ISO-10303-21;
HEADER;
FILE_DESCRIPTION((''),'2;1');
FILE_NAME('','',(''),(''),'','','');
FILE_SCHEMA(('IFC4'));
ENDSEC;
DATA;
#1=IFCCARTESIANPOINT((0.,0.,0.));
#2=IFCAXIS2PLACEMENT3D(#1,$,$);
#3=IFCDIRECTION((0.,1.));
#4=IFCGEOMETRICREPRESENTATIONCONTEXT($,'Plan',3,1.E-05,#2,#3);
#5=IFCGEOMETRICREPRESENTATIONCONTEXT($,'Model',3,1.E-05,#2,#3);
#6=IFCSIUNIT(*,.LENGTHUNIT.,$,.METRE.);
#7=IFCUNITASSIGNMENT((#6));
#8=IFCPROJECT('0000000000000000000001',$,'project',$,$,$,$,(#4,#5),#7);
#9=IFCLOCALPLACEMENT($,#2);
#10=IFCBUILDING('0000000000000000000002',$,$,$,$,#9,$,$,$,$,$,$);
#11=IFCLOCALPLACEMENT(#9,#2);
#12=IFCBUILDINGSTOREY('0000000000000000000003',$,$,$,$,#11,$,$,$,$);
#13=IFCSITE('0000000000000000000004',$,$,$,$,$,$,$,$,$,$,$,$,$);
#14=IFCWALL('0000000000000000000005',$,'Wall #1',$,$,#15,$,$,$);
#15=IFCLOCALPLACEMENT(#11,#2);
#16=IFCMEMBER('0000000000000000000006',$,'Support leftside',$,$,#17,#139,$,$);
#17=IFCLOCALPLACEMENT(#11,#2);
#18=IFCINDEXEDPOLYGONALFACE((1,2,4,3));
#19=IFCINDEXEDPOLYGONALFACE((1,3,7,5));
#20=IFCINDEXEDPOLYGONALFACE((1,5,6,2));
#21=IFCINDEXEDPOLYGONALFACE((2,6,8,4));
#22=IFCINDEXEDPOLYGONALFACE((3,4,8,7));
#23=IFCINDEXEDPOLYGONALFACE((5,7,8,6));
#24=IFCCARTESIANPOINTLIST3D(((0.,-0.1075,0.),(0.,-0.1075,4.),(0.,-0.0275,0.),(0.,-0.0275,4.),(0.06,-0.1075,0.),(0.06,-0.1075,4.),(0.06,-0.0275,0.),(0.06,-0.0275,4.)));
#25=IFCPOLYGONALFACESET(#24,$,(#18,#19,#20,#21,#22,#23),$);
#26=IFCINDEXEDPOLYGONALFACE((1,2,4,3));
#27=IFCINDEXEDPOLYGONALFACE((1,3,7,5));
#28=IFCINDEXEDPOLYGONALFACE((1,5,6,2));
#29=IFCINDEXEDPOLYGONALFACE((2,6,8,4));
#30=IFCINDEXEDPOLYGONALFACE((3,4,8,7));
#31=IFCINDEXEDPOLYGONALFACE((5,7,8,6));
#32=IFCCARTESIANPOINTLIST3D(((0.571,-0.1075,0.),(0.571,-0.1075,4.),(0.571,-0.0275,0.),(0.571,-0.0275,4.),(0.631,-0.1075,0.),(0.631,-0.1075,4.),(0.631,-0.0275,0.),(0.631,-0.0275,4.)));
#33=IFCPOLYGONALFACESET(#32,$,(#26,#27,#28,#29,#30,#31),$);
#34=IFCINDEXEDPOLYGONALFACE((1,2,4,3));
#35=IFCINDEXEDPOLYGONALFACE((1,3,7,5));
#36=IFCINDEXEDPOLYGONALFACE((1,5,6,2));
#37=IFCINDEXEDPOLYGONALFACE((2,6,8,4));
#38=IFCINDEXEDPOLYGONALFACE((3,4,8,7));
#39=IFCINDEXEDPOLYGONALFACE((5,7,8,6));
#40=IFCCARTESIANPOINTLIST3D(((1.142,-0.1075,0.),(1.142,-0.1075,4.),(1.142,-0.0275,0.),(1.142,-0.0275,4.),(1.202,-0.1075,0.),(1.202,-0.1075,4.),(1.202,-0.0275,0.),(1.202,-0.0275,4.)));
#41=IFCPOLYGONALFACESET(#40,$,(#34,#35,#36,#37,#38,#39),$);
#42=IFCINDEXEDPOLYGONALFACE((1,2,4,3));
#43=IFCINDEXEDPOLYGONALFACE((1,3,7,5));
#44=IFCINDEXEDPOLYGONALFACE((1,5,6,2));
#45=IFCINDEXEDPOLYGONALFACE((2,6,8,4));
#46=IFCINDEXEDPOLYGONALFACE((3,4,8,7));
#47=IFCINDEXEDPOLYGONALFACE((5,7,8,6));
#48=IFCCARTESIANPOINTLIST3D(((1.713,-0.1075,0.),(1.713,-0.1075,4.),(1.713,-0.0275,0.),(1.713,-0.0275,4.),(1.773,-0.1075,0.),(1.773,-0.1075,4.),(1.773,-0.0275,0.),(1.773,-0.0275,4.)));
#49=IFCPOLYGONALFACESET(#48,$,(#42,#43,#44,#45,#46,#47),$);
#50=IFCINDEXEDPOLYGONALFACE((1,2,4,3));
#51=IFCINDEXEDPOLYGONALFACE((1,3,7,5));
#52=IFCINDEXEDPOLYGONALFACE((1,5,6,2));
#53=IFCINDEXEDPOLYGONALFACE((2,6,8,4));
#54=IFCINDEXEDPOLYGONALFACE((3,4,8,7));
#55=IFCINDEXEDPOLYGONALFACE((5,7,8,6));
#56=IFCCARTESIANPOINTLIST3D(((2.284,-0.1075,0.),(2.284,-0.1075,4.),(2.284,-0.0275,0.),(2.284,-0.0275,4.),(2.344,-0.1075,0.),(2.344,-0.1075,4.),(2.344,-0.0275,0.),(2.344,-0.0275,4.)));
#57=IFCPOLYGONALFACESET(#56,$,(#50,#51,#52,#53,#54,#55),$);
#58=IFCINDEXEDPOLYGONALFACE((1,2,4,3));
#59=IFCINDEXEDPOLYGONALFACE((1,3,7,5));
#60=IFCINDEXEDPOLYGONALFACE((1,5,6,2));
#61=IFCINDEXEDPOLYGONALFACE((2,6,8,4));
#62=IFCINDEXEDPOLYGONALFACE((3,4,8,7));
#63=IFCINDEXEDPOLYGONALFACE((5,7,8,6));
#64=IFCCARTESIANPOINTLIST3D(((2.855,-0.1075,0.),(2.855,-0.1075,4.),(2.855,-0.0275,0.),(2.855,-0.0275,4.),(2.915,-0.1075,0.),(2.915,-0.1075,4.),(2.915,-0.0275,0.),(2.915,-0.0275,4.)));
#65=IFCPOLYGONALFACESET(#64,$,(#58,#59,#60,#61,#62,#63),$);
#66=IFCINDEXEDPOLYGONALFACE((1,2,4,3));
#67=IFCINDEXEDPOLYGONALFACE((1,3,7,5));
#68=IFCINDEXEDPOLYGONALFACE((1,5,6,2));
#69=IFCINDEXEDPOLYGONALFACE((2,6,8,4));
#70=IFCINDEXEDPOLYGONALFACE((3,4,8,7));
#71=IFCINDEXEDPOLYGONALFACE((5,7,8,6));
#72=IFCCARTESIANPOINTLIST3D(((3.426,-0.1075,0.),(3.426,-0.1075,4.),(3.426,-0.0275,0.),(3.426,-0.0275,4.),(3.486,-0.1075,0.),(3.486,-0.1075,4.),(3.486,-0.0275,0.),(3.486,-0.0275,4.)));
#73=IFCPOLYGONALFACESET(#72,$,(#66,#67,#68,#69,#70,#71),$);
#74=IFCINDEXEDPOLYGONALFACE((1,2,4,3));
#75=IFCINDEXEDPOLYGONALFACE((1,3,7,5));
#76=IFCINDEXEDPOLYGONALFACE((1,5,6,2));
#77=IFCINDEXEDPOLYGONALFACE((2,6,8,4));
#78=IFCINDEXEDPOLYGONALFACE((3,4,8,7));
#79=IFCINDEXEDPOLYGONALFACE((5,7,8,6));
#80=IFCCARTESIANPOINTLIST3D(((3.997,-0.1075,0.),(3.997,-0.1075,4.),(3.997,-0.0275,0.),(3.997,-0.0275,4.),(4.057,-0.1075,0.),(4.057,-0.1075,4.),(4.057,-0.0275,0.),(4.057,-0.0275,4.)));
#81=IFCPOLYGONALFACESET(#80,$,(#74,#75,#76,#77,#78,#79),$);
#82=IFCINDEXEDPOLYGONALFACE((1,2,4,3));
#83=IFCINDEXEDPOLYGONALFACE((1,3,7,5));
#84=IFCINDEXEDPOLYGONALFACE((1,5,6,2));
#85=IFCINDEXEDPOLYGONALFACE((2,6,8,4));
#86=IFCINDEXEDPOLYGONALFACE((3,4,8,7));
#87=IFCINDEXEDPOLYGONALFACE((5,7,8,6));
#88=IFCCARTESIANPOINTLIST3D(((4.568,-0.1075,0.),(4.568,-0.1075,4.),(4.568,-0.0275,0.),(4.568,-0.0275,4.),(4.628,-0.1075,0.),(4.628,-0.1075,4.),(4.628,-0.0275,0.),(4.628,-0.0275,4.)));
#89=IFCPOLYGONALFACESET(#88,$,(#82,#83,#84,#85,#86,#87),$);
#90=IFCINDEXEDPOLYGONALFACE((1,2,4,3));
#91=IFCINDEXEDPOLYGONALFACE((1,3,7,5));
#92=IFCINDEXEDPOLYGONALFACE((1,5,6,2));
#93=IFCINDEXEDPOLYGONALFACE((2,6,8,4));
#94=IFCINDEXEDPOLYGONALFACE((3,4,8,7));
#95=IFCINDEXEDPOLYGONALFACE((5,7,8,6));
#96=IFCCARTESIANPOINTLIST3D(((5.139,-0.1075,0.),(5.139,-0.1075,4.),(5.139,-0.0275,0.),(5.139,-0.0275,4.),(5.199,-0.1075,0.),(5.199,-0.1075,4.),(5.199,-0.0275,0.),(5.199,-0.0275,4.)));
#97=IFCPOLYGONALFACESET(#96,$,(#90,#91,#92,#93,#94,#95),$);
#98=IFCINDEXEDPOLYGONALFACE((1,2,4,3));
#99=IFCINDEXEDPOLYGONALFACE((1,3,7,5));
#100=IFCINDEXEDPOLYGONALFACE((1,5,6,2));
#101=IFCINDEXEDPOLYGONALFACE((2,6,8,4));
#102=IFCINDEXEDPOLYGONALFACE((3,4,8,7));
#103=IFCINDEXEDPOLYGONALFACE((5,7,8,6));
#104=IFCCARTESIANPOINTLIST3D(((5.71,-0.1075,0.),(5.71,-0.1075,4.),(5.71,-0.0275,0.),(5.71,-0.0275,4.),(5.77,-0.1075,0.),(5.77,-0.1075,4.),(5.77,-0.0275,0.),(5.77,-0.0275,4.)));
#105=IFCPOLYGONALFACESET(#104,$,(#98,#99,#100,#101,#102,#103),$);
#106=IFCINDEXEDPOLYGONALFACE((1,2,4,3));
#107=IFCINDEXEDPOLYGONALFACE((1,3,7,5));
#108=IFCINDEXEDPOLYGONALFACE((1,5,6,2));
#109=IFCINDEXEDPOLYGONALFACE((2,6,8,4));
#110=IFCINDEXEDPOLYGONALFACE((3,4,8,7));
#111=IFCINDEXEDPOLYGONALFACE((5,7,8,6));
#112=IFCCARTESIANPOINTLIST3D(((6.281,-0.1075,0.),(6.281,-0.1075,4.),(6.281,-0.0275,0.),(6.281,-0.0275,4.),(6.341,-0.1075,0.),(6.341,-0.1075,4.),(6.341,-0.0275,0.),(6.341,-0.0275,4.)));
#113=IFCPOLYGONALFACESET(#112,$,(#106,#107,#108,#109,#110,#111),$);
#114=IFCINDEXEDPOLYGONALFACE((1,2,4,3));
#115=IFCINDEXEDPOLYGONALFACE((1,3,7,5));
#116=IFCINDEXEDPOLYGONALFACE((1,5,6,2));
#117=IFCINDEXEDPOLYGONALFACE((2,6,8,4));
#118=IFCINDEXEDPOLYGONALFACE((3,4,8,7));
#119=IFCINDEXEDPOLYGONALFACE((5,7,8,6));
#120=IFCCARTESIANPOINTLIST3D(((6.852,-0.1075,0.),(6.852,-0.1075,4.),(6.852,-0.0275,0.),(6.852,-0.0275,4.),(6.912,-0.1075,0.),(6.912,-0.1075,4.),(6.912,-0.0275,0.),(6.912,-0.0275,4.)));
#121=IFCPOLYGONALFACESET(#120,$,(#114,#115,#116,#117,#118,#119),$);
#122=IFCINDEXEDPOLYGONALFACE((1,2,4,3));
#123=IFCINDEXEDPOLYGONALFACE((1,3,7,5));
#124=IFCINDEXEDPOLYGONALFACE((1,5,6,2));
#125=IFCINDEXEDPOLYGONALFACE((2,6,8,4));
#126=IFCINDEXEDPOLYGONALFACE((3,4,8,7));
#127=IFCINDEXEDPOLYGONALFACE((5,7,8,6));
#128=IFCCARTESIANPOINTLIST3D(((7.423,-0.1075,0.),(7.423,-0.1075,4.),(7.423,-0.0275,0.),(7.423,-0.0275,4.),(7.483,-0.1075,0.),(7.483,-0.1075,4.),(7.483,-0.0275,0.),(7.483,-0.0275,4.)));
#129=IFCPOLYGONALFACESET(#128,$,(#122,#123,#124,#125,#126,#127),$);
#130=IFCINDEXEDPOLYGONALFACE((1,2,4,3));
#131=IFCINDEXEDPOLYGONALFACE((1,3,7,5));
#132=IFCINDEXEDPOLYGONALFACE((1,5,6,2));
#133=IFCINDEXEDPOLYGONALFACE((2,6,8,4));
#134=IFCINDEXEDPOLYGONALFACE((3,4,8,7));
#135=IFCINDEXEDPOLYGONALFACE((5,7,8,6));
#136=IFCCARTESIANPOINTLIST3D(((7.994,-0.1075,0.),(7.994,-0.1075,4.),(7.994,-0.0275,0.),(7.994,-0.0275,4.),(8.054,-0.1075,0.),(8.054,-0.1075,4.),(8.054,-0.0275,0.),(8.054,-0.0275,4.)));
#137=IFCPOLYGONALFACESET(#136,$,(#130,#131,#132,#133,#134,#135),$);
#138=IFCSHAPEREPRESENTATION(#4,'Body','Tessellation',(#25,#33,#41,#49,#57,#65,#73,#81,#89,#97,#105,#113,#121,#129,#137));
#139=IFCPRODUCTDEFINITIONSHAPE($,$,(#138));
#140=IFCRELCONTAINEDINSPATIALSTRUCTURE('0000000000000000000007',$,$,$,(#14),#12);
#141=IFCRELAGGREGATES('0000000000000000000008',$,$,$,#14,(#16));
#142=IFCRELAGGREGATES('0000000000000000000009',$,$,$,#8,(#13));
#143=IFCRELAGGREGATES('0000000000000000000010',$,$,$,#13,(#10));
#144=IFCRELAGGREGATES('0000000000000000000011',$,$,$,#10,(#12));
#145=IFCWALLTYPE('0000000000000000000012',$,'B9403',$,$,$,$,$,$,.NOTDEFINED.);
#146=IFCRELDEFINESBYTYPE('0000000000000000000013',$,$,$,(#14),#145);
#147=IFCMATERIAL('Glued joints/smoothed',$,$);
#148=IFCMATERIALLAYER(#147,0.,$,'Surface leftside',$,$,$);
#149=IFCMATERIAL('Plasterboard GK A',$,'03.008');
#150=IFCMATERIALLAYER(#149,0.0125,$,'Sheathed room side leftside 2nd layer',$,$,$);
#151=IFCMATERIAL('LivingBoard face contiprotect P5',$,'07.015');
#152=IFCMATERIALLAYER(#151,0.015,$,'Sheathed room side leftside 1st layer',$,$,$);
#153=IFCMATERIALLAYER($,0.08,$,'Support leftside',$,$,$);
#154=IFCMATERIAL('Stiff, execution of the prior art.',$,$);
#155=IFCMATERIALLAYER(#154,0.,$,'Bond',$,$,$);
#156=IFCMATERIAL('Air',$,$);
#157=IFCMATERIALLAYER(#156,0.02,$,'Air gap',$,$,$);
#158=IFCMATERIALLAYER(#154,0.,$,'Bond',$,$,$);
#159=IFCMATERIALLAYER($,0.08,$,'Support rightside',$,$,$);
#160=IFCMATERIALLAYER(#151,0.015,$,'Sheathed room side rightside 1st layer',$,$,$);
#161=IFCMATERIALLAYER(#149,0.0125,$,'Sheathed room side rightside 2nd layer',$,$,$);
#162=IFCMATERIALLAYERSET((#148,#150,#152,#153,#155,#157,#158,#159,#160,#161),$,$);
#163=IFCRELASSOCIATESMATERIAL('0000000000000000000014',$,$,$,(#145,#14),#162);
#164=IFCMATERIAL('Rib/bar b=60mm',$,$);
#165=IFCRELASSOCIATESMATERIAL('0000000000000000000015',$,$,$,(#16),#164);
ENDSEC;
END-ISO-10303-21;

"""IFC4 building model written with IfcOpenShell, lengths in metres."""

from ifc_helpers import new_model, si_unit, direction, frame, frame_2d, origin, place, context, project, spatial, rectangle, extrude, material, layer, layer_set, type_object, element, aggregate, save


model = new_model("IFC4")

# Units and contexts
plan_context = context("Plan", 3, precision=1e-05, world=origin(), true_north=direction((0.0, 1.0)))
model_context = context("Model", 3, precision=1e-05, world=origin(), true_north=direction((0.0, 1.0)))
ifc_project = project(units=[si_unit("LENGTHUNIT", "METRE")], contexts=[plan_context, model_context])

# Site, building, storey
site = spatial("IfcSite", under=ifc_project)
building_placement = place(None, origin())
building = spatial("IfcBuilding", under=site, at=building_placement)
storey_placement = place(building_placement, origin())
storey = spatial("IfcBuildingStorey", under=building, at=storey_placement)

# Wall, member
ifc_material_1 = material(Name="Glued joints/smoothed")
ifc_layer_1 = layer(ifc_material_1, 0.0, Name="Surface leftside")
ifc_material_2 = material(Name="Plasterboard GK A", Category="03.008")
ifc_layer_2 = layer(ifc_material_2, 0.0125, Name="Sheathed room side leftside 2nd layer")
ifc_material_3 = material(Name="LivingBoard face contiprotect P5", Category="07.015")
ifc_layer_3 = layer(ifc_material_3, 0.015, Name="Sheathed room side leftside 1st layer")
ifc_layer_4 = layer(None, 0.08, Name="Support leftside")
ifc_material_4 = material(Name="Stiff, execution of the prior art.")
ifc_layer_5 = layer(ifc_material_4, 0.0, Name="Bond")
ifc_material_5 = material(Name="Air")
ifc_layer_6 = layer(ifc_material_5, 0.02, Name="Air gap")
ifc_layer_7 = layer(ifc_material_4, 0.0, Name="Bond")
ifc_layer_8 = layer(None, 0.08, Name="Support rightside")
ifc_layer_9 = layer(ifc_material_3, 0.015, Name="Sheathed room side rightside 1st layer")
ifc_layer_10 = layer(ifc_material_2, 0.0125, Name="Sheathed room side rightside 2nd layer")
ifc_layer_set = layer_set([ifc_layer_1, ifc_layer_2, ifc_layer_3, ifc_layer_4, ifc_layer_5, ifc_layer_6, ifc_layer_7, ifc_layer_8, ifc_layer_9, ifc_layer_10])
wall_type = type_object("IfcWallType", Name="B9403", PredefinedType="NOTDEFINED", material=ifc_layer_set)
wall_placement = place(None, frame((0.0, 0.0, 0.0), z_axis=(0.0, -1.0, 0.0), x_axis=(1.0, 0.0, 0.0)))
wall = element("IfcWall", 1, at=wall_placement, inside=storey, type_object=wall_type, material=ifc_layer_set, Name="Wall #1")
ifc_material_6 = material(Name="Rib/bar b=60mm")
member_1_placement = place(wall_placement, origin())
member_1 = element("IfcMember", 2, at=member_1_placement, material=ifc_material_6, Name="Support leftside", context=plan_context, shape_type="SweptSolid", body=[
    extrude(rectangle(XDim=0.06, YDim=0.08, at=frame_2d((0.03, 0.04), x_axis=(1.0, 0.0))), frame((0.0, 4.0, 0.0275), z_axis=(0.0, -1.0, 0.0), x_axis=(1.0, 0.0, 0.0)), (0.0, 0.0, 1.0), 4.0),
    extrude(rectangle(XDim=0.06, YDim=0.08, at=frame_2d((0.03, 0.04), x_axis=(1.0, 0.0))), frame((0.571, 4.0, 0.0275), z_axis=(0.0, -1.0, 0.0), x_axis=(1.0, 0.0, 0.0)), (0.0, 0.0, 1.0), 4.0),
    extrude(rectangle(XDim=0.06, YDim=0.08, at=frame_2d((0.03, 0.04), x_axis=(1.0, 0.0))), frame((1.142, 4.0, 0.0275), z_axis=(0.0, -1.0, 0.0), x_axis=(1.0, 0.0, 0.0)), (0.0, 0.0, 1.0), 4.0),
    extrude(rectangle(XDim=0.06, YDim=0.08, at=frame_2d((0.03, 0.04), x_axis=(1.0, 0.0))), frame((1.713, 4.0, 0.0275), z_axis=(0.0, -1.0, 0.0), x_axis=(1.0, 0.0, 0.0)), (0.0, 0.0, 1.0), 4.0),
    extrude(rectangle(XDim=0.06, YDim=0.08, at=frame_2d((0.03, 0.04), x_axis=(1.0, 0.0))), frame((2.284, 4.0, 0.0275), z_axis=(0.0, -1.0, 0.0), x_axis=(1.0, 0.0, 0.0)), (0.0, 0.0, 1.0), 4.0),
    extrude(rectangle(XDim=0.06, YDim=0.08, at=frame_2d((0.03, 0.04), x_axis=(1.0, 0.0))), frame((2.855, 4.0, 0.0275), z_axis=(0.0, -1.0, 0.0), x_axis=(1.0, 0.0, 0.0)), (0.0, 0.0, 1.0), 4.0),
    extrude(rectangle(XDim=0.06, YDim=0.08, at=frame_2d((0.03, 0.04), x_axis=(1.0, 0.0))), frame((3.426, 4.0, 0.0275), z_axis=(0.0, -1.0, 0.0), x_axis=(1.0, 0.0, 0.0)), (0.0, 0.0, 1.0), 4.0),
    extrude(rectangle(XDim=0.06, YDim=0.08, at=frame_2d((0.03, 0.04), x_axis=(1.0, 0.0))), frame((3.997, 4.0, 0.0275), z_axis=(0.0, -1.0, 0.0), x_axis=(1.0, 0.0, 0.0)), (0.0, 0.0, 1.0), 4.0),
    extrude(rectangle(XDim=0.06, YDim=0.08, at=frame_2d((0.03, 0.04), x_axis=(1.0, 0.0))), frame((4.568, 4.0, 0.0275), z_axis=(0.0, -1.0, 0.0), x_axis=(1.0, 0.0, 0.0)), (0.0, 0.0, 1.0), 4.0),
    extrude(rectangle(XDim=0.06, YDim=0.08, at=frame_2d((0.03, 0.04), x_axis=(1.0, 0.0))), frame((5.139, 4.0, 0.0275), z_axis=(0.0, -1.0, 0.0), x_axis=(1.0, 0.0, 0.0)), (0.0, 0.0, 1.0), 4.0),
    extrude(rectangle(XDim=0.06, YDim=0.08, at=frame_2d((0.03, 0.04), x_axis=(1.0, 0.0))), frame((5.71, 4.0, 0.0275), z_axis=(0.0, -1.0, 0.0), x_axis=(1.0, 0.0, 0.0)), (0.0, 0.0, 1.0), 4.0),
    extrude(rectangle(XDim=0.06, YDim=0.08, at=frame_2d((0.03, 0.04), x_axis=(1.0, 0.0))), frame((6.281, 4.0, 0.0275), z_axis=(0.0, -1.0, 0.0), x_axis=(1.0, 0.0, 0.0)), (0.0, 0.0, 1.0), 4.0),
    extrude(rectangle(XDim=0.06, YDim=0.08, at=frame_2d((0.03, 0.04), x_axis=(1.0, 0.0))), frame((6.852, 4.0, 0.0275), z_axis=(0.0, -1.0, 0.0), x_axis=(1.0, 0.0, 0.0)), (0.0, 0.0, 1.0), 4.0),
    extrude(rectangle(XDim=0.06, YDim=0.08, at=frame_2d((0.03, 0.04), x_axis=(1.0, 0.0))), frame((7.423, 4.0, 0.0275), z_axis=(0.0, -1.0, 0.0), x_axis=(1.0, 0.0, 0.0)), (0.0, 0.0, 1.0), 4.0),
    extrude(rectangle(XDim=0.06, YDim=0.08, at=frame_2d((0.03, 0.04), x_axis=(1.0, 0.0))), frame((7.994, 4.0, 0.0275), z_axis=(0.0, -1.0, 0.0), x_axis=(1.0, 0.0, 0.0)), (0.0, 0.0, 1.0), 4.0),
])
aggregate(wall, [member_1])

save(model, "model.ifc")
